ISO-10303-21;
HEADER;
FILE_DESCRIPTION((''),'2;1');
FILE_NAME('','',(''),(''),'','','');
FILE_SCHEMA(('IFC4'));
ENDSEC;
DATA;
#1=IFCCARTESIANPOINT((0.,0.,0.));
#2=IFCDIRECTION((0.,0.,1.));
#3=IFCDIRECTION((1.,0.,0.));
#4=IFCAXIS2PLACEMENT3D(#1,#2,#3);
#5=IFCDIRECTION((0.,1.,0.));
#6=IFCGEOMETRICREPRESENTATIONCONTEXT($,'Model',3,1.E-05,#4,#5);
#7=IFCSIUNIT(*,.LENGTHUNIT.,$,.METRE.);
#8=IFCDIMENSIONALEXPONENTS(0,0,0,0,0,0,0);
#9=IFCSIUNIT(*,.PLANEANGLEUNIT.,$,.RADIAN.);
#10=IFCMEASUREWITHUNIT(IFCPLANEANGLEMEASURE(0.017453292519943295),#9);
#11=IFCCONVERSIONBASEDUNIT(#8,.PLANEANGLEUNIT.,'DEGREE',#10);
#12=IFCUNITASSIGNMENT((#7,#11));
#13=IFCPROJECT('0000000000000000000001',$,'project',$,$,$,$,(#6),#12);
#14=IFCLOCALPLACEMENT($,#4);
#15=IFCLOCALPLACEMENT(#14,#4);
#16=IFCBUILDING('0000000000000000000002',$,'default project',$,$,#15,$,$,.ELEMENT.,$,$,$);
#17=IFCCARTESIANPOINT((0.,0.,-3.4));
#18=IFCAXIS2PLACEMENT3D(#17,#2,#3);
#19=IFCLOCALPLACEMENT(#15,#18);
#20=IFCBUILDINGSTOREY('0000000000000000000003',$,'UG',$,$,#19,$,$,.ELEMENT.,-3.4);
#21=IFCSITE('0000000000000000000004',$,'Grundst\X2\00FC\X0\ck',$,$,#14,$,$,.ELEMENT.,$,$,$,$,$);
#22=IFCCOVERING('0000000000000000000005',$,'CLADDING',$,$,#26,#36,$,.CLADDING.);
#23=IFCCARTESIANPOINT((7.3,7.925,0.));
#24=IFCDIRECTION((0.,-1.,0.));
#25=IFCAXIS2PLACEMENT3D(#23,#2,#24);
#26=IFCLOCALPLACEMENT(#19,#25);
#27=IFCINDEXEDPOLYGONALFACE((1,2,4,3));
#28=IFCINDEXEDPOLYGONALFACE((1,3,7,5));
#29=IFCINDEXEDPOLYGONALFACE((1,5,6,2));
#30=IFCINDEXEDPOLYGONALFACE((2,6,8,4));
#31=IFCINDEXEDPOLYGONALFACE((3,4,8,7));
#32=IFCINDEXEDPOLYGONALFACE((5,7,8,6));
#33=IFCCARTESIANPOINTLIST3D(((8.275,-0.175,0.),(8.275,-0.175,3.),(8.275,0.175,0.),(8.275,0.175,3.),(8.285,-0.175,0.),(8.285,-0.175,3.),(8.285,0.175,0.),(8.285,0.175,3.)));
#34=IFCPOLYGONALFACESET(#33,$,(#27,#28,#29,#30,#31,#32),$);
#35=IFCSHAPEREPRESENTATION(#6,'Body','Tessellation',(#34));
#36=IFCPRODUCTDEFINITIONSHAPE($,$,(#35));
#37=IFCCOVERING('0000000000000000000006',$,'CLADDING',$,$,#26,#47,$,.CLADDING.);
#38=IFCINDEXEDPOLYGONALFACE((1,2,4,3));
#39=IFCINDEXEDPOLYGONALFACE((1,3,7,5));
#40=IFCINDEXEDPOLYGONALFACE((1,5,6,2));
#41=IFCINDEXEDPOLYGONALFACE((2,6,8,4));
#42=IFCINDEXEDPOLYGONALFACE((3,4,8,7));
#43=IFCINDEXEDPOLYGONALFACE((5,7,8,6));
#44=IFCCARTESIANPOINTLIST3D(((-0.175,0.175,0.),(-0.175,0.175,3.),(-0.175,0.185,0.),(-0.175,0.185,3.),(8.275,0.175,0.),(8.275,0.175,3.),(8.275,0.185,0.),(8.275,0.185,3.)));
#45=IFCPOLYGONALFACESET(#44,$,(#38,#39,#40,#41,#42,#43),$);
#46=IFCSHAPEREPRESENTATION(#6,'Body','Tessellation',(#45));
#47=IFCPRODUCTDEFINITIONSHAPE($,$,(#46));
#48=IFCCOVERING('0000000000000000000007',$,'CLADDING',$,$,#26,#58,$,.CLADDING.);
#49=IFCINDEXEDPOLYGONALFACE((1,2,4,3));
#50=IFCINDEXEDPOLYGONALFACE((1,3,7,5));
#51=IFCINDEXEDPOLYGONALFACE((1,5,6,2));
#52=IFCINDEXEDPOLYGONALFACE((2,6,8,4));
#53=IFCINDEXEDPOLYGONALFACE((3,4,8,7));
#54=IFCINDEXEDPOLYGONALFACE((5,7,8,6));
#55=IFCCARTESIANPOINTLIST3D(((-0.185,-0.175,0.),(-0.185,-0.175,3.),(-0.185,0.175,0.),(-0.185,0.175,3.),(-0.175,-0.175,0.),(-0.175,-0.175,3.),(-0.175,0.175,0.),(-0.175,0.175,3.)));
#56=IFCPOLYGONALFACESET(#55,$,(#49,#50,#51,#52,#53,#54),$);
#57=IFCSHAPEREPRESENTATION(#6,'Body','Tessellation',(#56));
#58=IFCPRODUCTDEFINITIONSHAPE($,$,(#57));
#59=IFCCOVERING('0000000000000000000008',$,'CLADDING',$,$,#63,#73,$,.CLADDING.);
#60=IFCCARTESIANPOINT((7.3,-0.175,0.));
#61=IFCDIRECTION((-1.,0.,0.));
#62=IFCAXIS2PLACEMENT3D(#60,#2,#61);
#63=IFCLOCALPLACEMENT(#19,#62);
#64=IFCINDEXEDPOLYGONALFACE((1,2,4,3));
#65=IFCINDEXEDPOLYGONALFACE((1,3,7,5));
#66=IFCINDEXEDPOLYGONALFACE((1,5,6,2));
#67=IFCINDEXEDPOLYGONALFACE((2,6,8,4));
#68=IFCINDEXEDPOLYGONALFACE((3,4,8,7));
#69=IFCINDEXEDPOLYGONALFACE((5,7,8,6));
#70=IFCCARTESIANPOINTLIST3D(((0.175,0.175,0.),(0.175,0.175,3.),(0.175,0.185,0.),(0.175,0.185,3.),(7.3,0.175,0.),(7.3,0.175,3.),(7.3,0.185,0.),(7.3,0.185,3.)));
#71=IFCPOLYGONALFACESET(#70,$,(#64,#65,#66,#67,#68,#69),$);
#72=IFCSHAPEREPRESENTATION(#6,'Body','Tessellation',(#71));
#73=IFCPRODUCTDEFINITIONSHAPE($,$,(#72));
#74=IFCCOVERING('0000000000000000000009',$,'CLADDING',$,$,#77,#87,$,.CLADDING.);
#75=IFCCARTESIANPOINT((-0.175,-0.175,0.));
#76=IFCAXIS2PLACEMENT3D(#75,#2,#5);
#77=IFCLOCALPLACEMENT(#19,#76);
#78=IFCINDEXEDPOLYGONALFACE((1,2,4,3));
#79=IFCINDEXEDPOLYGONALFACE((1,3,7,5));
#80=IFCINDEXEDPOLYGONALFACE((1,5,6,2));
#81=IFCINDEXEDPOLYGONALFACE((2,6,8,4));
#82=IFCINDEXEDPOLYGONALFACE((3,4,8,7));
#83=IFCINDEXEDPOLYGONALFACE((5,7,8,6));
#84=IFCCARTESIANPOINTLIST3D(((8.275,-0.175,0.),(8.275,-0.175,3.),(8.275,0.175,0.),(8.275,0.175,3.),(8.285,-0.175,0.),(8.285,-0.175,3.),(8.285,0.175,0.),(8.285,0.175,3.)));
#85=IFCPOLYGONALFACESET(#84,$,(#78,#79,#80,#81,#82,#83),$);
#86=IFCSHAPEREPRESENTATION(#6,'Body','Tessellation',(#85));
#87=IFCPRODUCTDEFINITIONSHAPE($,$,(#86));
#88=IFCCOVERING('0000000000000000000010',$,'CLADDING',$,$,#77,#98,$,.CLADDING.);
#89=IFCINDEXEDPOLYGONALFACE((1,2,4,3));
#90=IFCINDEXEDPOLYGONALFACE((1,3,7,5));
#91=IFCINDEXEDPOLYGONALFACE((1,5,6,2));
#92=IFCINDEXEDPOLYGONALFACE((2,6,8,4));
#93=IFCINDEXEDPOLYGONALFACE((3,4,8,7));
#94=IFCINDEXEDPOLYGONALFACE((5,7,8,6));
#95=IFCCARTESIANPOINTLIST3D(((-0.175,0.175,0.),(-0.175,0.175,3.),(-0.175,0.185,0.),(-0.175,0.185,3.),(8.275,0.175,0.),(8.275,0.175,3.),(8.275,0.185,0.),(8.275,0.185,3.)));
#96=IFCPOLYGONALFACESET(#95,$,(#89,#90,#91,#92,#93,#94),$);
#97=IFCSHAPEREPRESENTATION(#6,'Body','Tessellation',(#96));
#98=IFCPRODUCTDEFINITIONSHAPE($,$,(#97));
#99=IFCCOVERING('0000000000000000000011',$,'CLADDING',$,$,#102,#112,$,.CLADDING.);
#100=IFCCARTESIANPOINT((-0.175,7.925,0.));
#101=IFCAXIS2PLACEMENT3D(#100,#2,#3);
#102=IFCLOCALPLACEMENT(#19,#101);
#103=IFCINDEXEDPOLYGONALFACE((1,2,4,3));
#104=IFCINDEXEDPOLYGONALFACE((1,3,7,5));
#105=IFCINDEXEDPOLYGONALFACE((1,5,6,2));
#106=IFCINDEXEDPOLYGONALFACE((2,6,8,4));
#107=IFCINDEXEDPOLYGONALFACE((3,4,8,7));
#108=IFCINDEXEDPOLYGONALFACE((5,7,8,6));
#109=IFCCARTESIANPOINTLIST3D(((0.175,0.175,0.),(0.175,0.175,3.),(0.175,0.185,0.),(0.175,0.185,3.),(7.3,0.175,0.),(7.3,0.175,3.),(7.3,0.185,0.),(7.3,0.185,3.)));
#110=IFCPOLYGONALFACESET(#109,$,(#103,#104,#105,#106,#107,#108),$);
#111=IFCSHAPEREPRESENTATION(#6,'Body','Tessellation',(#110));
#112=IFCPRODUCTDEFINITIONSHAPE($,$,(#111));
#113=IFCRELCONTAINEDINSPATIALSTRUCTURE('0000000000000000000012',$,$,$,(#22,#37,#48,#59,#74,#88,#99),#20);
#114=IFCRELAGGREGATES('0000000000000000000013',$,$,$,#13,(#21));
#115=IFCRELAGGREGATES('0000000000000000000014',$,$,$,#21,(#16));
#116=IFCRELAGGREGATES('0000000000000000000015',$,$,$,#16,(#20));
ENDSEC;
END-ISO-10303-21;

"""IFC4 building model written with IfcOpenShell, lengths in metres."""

from ifc_helpers import new_model, entity, si_unit, converted_unit, direction, frame, origin_with_axes, place, context, project, spatial, polyline, outline, extrude, element, save


model = new_model("IFC4")

# Units and contexts
model_context = context("Model", 3, precision=1e-05, world=origin_with_axes(), true_north=direction((0.0, 1.0, 0.0)))
ifc_project = project(units=[si_unit("LENGTHUNIT", "METRE"), converted_unit("PLANEANGLEUNIT", "DEGREE", entity("IfcPlaneAngleMeasure", 0.017453292519943295), si_unit("PLANEANGLEUNIT", "RADIAN"), dimensions=[0, 0, 0, 0, 0, 0, 0])], contexts=[model_context])

# Site, building, storey
site_placement = place(None, origin_with_axes())
site = spatial("IfcSite", under=ifc_project, at=site_placement, Name="Grundstück", CompositionType="ELEMENT")
building_placement = place(site_placement, origin_with_axes())
building = spatial("IfcBuilding", under=site, at=building_placement, Name="default project", CompositionType="ELEMENT")
placement_1 = place(building_placement, frame((0.0, 0.0, -3.4), z_axis=(0.0, 0.0, 1.0), x_axis=(1.0, 0.0, 0.0)))
storey = spatial("IfcBuildingStorey", under=building, at=placement_1, Name="UG", CompositionType="ELEMENT", Elevation=-3.4)

# Shared definitions
placement_2 = place(placement_1, frame((7.3, 7.925, 0.0), z_axis=(0.0, 0.0, 1.0), x_axis=(0.0, -1.0, 0.0)))
placement_3 = place(placement_1, frame((7.3, -0.175, 0.0), z_axis=(0.0, 0.0, 1.0), x_axis=(-1.0, 0.0, 0.0)))
placement_4 = place(placement_1, frame((-0.175, -0.175, 0.0), z_axis=(0.0, 0.0, 1.0), x_axis=(0.0, 1.0, 0.0)))
placement_5 = place(placement_1, frame((-0.175, 7.925, 0.0), z_axis=(0.0, 0.0, 1.0), x_axis=(1.0, 0.0, 0.0)))

# Coverings
element("IfcCovering", 1, at=placement_2, inside=storey, Name="CLADDING", PredefinedType="CLADDING", context=model_context, shape_type="SweptSolid", body=[
    extrude(outline(polyline([(8.285, -0.175), (8.285, 0.175), (8.275, 0.175), (8.275, -0.175), (8.285, -0.175)])), origin_with_axes(), (0.0, 0.0, 1.0), 3.0),
])
element("IfcCovering", 2, at=placement_2, inside=storey, Name="CLADDING", PredefinedType="CLADDING", context=model_context, shape_type="SweptSolid", body=[
    extrude(outline(polyline([(8.275, 0.185), (-0.175, 0.185), (-0.175, 0.175), (8.275, 0.175), (8.275, 0.185)])), origin_with_axes(), (0.0, 0.0, 1.0), 3.0),
])
element("IfcCovering", 3, at=placement_2, inside=storey, Name="CLADDING", PredefinedType="CLADDING", context=model_context, shape_type="SweptSolid", body=[
    extrude(outline(polyline([(-0.185, 0.175), (-0.185, -0.175), (-0.175, -0.175), (-0.175, 0.175), (-0.185, 0.175)])), origin_with_axes(), (0.0, 0.0, 1.0), 3.0),
])
element("IfcCovering", 4, at=placement_3, inside=storey, Name="CLADDING", PredefinedType="CLADDING", context=model_context, shape_type="SweptSolid", body=[
    extrude(outline(polyline([(7.3, 0.185), (0.175, 0.185), (0.175, 0.175), (7.3, 0.175), (7.3, 0.185)])), origin_with_axes(), (0.0, 0.0, 1.0), 3.0),
])
element("IfcCovering", 5, at=placement_4, inside=storey, Name="CLADDING", PredefinedType="CLADDING", context=model_context, shape_type="SweptSolid", body=[
    extrude(outline(polyline([(8.285, -0.175), (8.285, 0.175), (8.275, 0.175), (8.275, -0.175), (8.285, -0.175)])), origin_with_axes(), (0.0, 0.0, 1.0), 3.0),
])
element("IfcCovering", 6, at=placement_4, inside=storey, Name="CLADDING", PredefinedType="CLADDING", context=model_context, shape_type="SweptSolid", body=[
    extrude(outline(polyline([(8.275, 0.185), (-0.175, 0.185), (-0.175, 0.175), (8.275, 0.175), (8.275, 0.185)])), origin_with_axes(), (0.0, 0.0, 1.0), 3.0),
])
element("IfcCovering", 7, at=placement_5, inside=storey, Name="CLADDING", PredefinedType="CLADDING", context=model_context, shape_type="SweptSolid", body=[
    extrude(outline(polyline([(7.3, 0.185), (0.175, 0.185), (0.175, 0.175), (7.3, 0.175), (7.3, 0.185)])), origin_with_axes(), (0.0, 0.0, 1.0), 3.0),
])

save(model, "model.ifc")
